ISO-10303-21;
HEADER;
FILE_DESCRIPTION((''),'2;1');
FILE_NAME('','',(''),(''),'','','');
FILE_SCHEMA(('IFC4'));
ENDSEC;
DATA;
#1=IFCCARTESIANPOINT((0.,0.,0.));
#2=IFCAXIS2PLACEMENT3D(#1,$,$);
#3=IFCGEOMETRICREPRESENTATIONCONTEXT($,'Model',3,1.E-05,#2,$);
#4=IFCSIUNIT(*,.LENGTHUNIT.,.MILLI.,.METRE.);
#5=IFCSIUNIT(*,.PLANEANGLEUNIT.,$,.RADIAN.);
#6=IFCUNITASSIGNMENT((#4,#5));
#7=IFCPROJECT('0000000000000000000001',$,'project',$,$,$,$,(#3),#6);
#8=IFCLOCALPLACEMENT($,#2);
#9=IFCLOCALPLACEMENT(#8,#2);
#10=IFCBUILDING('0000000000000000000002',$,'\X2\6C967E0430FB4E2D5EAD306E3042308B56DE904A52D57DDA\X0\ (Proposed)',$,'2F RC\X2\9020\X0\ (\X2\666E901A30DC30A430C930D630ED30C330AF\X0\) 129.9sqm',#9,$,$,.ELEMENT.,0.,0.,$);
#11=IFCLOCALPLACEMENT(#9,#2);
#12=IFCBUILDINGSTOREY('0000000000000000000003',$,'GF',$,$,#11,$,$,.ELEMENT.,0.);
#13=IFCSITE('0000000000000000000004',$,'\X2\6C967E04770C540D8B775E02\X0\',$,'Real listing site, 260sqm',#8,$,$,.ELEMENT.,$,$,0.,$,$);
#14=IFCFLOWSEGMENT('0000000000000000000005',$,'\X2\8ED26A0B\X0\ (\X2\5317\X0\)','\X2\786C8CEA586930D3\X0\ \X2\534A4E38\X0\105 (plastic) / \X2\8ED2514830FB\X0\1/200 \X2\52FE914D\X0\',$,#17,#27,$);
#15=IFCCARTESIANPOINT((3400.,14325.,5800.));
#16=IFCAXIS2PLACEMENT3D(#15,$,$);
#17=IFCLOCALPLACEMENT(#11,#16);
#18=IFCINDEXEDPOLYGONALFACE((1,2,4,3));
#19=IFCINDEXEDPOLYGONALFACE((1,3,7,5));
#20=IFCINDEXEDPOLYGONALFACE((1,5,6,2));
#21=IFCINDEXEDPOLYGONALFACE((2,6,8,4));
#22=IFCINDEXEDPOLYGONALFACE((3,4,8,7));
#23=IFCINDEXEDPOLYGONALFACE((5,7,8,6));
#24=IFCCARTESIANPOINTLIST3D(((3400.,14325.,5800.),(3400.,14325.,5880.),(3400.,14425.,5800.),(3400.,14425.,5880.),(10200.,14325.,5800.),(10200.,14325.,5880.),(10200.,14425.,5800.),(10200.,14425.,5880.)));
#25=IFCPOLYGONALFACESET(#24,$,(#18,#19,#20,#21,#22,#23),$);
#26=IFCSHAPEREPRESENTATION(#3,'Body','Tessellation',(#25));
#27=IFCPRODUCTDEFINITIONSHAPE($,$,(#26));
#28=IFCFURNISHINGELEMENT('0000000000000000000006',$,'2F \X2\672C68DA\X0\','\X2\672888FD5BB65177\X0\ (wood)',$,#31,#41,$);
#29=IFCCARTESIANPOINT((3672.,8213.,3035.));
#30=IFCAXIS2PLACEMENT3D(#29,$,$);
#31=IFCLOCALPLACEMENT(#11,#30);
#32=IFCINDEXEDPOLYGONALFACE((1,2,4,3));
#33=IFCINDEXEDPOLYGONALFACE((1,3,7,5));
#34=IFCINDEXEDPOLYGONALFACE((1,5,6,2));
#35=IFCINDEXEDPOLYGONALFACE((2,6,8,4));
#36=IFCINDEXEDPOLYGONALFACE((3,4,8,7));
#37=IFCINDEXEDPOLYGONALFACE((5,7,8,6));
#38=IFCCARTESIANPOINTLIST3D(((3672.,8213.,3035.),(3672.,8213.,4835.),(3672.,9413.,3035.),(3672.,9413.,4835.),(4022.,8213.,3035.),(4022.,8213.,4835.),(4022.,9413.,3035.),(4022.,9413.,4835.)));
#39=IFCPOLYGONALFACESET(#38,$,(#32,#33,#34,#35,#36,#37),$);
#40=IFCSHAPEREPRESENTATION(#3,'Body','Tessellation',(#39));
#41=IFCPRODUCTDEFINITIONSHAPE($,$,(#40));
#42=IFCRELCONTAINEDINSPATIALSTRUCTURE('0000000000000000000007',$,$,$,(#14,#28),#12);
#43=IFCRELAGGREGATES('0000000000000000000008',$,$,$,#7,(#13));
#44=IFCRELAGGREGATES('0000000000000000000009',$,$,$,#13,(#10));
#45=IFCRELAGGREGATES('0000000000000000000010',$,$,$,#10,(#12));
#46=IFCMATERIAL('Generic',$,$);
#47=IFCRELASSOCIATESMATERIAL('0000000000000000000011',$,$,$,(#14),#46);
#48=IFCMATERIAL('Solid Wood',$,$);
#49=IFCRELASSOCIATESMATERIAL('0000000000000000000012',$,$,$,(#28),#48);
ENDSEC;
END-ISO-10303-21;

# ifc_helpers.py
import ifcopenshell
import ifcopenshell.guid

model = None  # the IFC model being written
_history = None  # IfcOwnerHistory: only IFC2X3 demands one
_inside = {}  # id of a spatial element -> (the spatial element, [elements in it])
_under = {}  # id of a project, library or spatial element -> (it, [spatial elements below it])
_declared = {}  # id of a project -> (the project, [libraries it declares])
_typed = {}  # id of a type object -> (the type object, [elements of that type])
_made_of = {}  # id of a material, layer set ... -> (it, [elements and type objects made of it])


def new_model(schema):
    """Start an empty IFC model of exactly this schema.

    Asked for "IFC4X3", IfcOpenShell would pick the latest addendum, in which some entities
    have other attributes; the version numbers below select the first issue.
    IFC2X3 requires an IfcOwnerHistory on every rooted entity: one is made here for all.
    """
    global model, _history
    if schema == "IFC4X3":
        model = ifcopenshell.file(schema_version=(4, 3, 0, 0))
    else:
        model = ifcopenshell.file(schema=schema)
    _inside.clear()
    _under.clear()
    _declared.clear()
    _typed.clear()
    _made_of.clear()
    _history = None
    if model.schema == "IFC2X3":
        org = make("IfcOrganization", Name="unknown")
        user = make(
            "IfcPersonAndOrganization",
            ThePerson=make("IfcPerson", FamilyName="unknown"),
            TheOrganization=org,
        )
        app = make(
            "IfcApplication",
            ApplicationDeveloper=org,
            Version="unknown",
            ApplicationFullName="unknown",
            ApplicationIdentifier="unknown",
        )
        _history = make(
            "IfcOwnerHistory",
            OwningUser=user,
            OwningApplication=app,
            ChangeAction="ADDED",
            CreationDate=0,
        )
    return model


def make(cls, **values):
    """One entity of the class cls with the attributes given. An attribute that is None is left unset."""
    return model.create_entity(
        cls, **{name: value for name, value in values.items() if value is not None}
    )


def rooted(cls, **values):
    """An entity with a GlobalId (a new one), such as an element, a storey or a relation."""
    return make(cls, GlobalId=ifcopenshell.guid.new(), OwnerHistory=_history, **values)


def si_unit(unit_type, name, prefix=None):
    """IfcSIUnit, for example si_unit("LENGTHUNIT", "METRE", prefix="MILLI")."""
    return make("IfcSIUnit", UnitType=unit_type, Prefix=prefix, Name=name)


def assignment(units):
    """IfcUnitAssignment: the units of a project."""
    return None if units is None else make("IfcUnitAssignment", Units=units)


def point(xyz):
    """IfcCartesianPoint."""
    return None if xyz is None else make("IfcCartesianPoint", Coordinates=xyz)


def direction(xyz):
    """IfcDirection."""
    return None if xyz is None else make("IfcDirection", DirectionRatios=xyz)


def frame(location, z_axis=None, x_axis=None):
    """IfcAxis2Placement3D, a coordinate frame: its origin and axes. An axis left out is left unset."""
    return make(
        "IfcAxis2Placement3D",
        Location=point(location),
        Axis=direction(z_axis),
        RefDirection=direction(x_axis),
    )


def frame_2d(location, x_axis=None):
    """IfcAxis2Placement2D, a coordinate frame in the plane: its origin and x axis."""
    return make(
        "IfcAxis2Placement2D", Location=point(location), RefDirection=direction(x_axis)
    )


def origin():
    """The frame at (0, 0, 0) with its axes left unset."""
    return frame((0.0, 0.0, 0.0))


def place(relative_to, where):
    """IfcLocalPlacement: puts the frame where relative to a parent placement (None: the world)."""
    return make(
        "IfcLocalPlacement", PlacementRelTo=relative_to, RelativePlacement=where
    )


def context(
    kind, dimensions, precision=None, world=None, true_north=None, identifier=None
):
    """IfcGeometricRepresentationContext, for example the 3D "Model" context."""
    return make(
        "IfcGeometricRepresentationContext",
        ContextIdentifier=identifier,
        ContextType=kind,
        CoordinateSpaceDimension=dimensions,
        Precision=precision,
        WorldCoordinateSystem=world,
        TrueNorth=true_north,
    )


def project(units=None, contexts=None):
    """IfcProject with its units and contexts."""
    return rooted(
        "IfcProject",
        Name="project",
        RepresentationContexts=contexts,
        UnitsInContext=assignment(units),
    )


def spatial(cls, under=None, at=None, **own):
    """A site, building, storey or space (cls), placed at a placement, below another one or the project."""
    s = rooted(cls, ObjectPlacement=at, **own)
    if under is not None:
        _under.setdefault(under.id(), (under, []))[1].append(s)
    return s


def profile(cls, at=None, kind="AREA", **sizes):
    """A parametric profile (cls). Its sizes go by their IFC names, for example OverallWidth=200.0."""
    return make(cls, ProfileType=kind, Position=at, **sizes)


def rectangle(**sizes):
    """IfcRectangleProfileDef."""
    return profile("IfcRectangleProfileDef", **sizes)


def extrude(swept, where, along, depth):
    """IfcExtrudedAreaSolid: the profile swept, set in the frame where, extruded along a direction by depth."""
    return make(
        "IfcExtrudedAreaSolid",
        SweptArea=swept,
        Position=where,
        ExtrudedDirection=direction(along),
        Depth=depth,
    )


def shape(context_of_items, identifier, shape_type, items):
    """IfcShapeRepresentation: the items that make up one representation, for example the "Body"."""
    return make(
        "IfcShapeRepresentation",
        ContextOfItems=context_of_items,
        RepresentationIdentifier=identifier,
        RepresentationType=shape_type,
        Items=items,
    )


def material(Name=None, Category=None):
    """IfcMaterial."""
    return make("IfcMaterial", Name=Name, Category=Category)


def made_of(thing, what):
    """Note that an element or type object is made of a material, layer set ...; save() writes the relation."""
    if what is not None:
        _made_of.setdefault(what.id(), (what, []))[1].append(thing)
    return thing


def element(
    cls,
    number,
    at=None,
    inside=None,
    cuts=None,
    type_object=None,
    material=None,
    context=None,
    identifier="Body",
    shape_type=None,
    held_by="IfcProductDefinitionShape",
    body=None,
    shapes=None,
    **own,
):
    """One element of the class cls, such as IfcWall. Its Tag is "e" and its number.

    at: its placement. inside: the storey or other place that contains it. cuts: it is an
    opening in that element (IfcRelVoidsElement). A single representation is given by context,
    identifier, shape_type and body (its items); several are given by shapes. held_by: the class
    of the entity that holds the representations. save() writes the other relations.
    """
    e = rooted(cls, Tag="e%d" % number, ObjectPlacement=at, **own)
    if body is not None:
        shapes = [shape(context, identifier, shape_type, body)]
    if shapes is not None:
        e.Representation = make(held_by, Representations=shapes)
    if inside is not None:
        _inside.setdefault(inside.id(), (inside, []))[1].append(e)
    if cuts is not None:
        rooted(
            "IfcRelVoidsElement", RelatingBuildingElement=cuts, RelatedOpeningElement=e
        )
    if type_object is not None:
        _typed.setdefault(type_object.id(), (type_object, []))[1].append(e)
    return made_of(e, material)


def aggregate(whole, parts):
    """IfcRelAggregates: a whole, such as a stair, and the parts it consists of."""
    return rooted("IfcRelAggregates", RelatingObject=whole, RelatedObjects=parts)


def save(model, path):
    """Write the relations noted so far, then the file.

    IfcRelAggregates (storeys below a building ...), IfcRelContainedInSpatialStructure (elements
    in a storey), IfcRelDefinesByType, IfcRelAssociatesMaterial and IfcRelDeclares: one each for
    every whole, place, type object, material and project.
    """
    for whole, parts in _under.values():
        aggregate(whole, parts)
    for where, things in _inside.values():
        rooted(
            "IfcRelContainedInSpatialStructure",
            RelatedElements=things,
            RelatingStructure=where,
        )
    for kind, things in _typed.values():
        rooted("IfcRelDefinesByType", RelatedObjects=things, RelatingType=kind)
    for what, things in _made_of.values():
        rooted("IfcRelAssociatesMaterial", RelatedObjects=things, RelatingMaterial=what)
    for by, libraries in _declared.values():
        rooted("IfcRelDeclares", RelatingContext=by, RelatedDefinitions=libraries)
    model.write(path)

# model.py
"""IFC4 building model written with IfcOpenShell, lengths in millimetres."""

from ifc_helpers import new_model, si_unit, frame, frame_2d, origin, place, context, project, spatial, rectangle, extrude, material, element, save


model = new_model("IFC4")

# Units and contexts
model_context = context("Model", 3, precision=1e-05, world=origin())
ifc_project = project(units=[si_unit("LENGTHUNIT", "METRE", prefix="MILLI"), si_unit("PLANEANGLEUNIT", "RADIAN")], contexts=[model_context])

# Site, building, storey
site_placement = place(None, origin())
site = spatial("IfcSite", under=ifc_project, at=site_placement, Name="沖縄県名護市", ObjectType="Real listing site, 260sqm", CompositionType="ELEMENT", RefElevation=0.0)
building_placement = place(site_placement, origin())
building = spatial("IfcBuilding", under=site, at=building_placement, Name="沖縄・中庭のある回遊動線 (Proposed)", ObjectType="2F RC造 (普通ボイドブロック) 129.9sqm", CompositionType="ELEMENT", ElevationOfRefHeight=0.0, ElevationOfTerrain=0.0)
storey_placement = place(building_placement, origin())
storey = spatial("IfcBuildingStorey", under=building, at=storey_placement, Name="GF", CompositionType="ELEMENT", Elevation=0.0)

# Shared definitions
ifc_material_1 = material(Name="Solid Wood")

# Shared definitions
ifc_material_2 = material(Name="Generic")

# Flow segment
flow_segment_placement = place(storey_placement, frame((3400.0, 14325.0, 5800.0)))
element("IfcFlowSegment", 1, at=flow_segment_placement, inside=storey, material=ifc_material_2, Name="軒樋 (北)", Description="硬質塩ビ 半丸105 (plastic) / 軒先・1/200 勾配", context=model_context, shape_type="SweptSolid", body=[
    extrude(rectangle(XDim=6800.0, YDim=100.0, at=frame_2d((3400.0, 50.0))), frame((3400.0, 14325.0, 5800.0)), (0.0, 0.0, 1.0), 80.0),
])

# Furnishing element
furnishing_placement = place(storey_placement, frame((3672.0, 8213.0, 3035.0)))
element("IfcFurnishingElement", 2, at=furnishing_placement, inside=storey, material=ifc_material_1, Name="2F 本棚", Description="木製家具 (wood)", context=model_context, shape_type="SweptSolid", body=[
    extrude(rectangle(XDim=350.0, YDim=1200.0, at=frame_2d((175.0, 600.0))), frame((3672.0, 8213.0, 3035.0)), (0.0, 0.0, 1.0), 1800.0),
])

save(model, "model.ifc")
